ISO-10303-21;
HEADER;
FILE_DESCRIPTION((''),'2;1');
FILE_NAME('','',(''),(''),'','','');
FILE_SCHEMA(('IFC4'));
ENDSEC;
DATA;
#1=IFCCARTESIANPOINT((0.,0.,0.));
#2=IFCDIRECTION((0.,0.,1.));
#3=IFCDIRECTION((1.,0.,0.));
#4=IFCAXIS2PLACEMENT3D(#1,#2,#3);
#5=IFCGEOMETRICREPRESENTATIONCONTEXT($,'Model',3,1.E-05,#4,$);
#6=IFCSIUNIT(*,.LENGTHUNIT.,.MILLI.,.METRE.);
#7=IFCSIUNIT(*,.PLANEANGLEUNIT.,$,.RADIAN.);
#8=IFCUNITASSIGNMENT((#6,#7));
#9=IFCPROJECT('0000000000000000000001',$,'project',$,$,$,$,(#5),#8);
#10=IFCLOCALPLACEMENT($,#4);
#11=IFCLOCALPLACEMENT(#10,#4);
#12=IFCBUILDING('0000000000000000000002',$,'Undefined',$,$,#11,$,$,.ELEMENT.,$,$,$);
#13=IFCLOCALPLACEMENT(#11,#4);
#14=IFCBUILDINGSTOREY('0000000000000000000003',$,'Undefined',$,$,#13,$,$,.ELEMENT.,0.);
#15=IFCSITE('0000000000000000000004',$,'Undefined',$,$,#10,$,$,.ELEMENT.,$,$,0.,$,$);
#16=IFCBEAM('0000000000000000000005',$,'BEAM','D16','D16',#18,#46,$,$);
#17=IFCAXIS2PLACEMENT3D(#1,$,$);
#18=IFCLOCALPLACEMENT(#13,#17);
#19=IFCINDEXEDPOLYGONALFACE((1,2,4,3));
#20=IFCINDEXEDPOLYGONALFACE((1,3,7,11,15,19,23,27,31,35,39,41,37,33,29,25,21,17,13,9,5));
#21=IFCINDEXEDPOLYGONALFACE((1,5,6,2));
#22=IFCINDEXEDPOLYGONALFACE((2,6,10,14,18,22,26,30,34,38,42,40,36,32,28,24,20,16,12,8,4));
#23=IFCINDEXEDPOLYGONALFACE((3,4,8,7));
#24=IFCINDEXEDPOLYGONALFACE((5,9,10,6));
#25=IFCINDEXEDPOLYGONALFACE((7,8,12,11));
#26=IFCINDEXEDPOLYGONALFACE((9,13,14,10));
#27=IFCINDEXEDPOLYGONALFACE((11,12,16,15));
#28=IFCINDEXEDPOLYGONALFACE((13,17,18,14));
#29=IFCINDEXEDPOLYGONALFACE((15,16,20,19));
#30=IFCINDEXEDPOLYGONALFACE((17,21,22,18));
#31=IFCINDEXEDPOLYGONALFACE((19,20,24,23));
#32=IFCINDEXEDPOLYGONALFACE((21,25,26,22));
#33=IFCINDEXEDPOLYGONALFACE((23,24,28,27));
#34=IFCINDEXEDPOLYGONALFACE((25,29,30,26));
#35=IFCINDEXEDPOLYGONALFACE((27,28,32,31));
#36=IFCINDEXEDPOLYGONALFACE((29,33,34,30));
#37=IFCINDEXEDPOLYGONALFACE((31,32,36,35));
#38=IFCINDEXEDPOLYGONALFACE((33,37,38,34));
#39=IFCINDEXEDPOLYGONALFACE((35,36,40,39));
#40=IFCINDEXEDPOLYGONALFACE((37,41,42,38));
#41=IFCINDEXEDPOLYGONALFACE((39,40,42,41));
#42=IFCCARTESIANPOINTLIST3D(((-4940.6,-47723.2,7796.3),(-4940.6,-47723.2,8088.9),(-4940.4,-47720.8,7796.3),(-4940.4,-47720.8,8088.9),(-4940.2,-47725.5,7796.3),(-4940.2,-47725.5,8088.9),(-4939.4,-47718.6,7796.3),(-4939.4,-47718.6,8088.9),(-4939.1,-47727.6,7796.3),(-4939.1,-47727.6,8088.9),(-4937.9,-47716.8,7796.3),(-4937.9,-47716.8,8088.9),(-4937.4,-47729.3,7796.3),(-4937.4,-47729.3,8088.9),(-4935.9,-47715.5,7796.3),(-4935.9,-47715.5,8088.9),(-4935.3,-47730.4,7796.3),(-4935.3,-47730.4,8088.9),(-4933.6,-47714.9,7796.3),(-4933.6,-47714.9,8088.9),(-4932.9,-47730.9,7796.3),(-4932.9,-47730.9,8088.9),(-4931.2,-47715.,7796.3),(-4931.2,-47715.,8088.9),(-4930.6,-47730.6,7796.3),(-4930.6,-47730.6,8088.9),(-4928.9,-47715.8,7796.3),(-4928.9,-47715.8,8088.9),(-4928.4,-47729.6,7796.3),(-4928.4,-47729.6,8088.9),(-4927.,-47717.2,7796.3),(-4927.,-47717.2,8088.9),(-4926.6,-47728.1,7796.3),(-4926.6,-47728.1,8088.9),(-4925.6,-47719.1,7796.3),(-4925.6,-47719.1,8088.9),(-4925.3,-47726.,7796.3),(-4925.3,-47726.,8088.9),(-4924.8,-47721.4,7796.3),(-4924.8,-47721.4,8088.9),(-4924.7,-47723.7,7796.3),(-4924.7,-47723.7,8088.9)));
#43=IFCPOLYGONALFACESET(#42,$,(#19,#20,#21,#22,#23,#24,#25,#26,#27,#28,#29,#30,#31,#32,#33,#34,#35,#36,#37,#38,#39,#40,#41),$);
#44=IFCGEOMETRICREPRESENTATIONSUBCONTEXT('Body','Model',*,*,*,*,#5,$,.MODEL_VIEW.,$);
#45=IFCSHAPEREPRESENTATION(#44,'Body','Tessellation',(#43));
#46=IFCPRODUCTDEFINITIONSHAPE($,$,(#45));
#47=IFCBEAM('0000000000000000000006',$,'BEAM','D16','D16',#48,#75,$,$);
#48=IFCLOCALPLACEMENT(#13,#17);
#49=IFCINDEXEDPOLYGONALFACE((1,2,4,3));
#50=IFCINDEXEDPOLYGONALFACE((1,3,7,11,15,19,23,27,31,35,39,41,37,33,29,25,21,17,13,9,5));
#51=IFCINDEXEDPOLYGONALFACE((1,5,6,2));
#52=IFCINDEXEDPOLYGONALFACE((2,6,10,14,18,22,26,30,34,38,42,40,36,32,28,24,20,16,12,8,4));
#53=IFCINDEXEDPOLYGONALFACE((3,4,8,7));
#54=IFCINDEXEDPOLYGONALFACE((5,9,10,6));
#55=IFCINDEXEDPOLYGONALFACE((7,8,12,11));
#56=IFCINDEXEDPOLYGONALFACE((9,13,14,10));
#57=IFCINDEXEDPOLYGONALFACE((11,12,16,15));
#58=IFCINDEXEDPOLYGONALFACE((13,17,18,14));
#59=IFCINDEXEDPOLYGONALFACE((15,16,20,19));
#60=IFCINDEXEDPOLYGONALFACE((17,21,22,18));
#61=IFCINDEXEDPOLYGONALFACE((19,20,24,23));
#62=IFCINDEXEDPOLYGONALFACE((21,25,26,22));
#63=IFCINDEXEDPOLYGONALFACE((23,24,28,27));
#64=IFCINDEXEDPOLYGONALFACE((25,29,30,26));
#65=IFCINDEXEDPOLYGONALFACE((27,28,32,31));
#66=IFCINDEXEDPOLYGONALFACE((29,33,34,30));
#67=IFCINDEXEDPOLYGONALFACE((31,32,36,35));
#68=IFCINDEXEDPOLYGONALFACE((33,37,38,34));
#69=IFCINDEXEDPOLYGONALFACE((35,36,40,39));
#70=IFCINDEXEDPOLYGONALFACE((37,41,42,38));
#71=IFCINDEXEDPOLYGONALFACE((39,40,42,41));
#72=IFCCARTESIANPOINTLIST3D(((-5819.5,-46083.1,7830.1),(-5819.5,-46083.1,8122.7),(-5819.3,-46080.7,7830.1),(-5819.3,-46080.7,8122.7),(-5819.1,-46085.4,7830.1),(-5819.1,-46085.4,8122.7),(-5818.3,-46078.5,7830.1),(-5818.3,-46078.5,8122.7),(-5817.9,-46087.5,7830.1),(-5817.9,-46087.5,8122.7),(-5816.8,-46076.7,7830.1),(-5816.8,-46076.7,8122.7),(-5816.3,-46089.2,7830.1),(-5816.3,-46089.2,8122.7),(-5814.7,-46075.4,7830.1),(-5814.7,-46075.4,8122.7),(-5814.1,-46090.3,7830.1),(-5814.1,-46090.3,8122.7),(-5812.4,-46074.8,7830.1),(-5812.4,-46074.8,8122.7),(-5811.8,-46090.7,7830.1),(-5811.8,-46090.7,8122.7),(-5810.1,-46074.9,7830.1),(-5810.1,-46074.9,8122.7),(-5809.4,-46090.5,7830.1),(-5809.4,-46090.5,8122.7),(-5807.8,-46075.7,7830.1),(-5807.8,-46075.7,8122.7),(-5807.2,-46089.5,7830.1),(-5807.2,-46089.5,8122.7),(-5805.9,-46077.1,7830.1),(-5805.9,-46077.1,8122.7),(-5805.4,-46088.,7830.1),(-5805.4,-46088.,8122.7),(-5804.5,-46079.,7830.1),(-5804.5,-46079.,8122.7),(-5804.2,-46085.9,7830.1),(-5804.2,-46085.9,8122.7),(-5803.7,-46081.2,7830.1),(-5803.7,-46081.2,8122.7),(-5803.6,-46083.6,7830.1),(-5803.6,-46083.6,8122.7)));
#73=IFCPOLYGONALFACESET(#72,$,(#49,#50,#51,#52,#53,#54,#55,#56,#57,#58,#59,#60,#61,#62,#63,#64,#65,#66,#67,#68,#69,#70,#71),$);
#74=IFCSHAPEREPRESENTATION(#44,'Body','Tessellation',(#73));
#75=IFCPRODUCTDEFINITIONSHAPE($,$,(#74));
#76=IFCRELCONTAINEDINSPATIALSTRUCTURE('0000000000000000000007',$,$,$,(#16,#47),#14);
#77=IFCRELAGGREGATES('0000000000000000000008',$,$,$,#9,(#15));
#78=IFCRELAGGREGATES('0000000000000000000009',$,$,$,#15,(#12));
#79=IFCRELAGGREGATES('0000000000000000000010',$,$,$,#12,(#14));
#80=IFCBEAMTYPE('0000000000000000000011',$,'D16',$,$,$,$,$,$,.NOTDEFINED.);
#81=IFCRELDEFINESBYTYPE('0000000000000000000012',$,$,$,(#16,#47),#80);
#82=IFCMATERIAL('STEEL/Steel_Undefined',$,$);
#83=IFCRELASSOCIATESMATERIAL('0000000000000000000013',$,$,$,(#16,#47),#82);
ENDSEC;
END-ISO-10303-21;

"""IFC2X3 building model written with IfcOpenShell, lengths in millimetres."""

from ifc_helpers import new_model, si_unit, frame, origin_with_axes, origin_2d_with_axis, place, context, subcontext, project, spatial, circle, extrude, material, type_object, element, save


model = new_model("IFC2X3")

# Units and contexts
model_context = context("Model", 3, precision=1e-05, world=origin_with_axes())
body_context = subcontext(model_context, "Body", "Model", "MODEL_VIEW")
ifc_project = project(units=[si_unit("LENGTHUNIT", "METRE", prefix="MILLI"), si_unit("PLANEANGLEUNIT", "RADIAN")], contexts=[model_context])

# Site, building, storey
site_placement = place(None, origin_with_axes())
site = spatial("IfcSite", under=ifc_project, at=site_placement, Name="Undefined", CompositionType="ELEMENT", RefElevation=0.0)
building_placement = place(site_placement, origin_with_axes())
building = spatial("IfcBuilding", under=site, at=building_placement, Name="Undefined", CompositionType="ELEMENT")
storey_placement = place(building_placement, origin_with_axes())
storey = spatial("IfcBuildingStorey", under=building, at=storey_placement, Name="Undefined", CompositionType="ELEMENT", Elevation=0.0)

# Shared definitions
ifc_material_1 = material(Name="STEEL/Steel_Undefined")

# Beams
beam_type_1 = type_object("IfcBeamType", Name="D16", PredefinedType="NOTDEFINED")
for number, where, z_axis, x_axis, name in (
    (1, (-4932.7, -47722.9, 8088.9), (-0.915553, -0.402198, 0.0), (0.0, 0.0, -1.0), "BEAM"),
    (2, (-5811.5, -46082.7, 8122.7), (-0.915553, -0.402198, 0.0), (0.0, 0.0, -1.0), "BEAM"),
):
    element("IfcBeam", number, at=place(storey_placement, frame(where, z_axis=z_axis, x_axis=x_axis)), inside=storey, type_object=beam_type_1, material=ifc_material_1, Name=name, Description="D16", ObjectType="D16", context=body_context, shape_type="SweptSolid", body=[
        extrude(circle(Radius=8.0, at=origin_2d_with_axis()), frame((292.6, 0.0, 0.0), z_axis=(-1.0, 0.0, 0.0), x_axis=(0.0, -1.0, 0.0)), (0.0, 0.0, 1.0), 292.6),
    ])

save(model, "model.ifc")
